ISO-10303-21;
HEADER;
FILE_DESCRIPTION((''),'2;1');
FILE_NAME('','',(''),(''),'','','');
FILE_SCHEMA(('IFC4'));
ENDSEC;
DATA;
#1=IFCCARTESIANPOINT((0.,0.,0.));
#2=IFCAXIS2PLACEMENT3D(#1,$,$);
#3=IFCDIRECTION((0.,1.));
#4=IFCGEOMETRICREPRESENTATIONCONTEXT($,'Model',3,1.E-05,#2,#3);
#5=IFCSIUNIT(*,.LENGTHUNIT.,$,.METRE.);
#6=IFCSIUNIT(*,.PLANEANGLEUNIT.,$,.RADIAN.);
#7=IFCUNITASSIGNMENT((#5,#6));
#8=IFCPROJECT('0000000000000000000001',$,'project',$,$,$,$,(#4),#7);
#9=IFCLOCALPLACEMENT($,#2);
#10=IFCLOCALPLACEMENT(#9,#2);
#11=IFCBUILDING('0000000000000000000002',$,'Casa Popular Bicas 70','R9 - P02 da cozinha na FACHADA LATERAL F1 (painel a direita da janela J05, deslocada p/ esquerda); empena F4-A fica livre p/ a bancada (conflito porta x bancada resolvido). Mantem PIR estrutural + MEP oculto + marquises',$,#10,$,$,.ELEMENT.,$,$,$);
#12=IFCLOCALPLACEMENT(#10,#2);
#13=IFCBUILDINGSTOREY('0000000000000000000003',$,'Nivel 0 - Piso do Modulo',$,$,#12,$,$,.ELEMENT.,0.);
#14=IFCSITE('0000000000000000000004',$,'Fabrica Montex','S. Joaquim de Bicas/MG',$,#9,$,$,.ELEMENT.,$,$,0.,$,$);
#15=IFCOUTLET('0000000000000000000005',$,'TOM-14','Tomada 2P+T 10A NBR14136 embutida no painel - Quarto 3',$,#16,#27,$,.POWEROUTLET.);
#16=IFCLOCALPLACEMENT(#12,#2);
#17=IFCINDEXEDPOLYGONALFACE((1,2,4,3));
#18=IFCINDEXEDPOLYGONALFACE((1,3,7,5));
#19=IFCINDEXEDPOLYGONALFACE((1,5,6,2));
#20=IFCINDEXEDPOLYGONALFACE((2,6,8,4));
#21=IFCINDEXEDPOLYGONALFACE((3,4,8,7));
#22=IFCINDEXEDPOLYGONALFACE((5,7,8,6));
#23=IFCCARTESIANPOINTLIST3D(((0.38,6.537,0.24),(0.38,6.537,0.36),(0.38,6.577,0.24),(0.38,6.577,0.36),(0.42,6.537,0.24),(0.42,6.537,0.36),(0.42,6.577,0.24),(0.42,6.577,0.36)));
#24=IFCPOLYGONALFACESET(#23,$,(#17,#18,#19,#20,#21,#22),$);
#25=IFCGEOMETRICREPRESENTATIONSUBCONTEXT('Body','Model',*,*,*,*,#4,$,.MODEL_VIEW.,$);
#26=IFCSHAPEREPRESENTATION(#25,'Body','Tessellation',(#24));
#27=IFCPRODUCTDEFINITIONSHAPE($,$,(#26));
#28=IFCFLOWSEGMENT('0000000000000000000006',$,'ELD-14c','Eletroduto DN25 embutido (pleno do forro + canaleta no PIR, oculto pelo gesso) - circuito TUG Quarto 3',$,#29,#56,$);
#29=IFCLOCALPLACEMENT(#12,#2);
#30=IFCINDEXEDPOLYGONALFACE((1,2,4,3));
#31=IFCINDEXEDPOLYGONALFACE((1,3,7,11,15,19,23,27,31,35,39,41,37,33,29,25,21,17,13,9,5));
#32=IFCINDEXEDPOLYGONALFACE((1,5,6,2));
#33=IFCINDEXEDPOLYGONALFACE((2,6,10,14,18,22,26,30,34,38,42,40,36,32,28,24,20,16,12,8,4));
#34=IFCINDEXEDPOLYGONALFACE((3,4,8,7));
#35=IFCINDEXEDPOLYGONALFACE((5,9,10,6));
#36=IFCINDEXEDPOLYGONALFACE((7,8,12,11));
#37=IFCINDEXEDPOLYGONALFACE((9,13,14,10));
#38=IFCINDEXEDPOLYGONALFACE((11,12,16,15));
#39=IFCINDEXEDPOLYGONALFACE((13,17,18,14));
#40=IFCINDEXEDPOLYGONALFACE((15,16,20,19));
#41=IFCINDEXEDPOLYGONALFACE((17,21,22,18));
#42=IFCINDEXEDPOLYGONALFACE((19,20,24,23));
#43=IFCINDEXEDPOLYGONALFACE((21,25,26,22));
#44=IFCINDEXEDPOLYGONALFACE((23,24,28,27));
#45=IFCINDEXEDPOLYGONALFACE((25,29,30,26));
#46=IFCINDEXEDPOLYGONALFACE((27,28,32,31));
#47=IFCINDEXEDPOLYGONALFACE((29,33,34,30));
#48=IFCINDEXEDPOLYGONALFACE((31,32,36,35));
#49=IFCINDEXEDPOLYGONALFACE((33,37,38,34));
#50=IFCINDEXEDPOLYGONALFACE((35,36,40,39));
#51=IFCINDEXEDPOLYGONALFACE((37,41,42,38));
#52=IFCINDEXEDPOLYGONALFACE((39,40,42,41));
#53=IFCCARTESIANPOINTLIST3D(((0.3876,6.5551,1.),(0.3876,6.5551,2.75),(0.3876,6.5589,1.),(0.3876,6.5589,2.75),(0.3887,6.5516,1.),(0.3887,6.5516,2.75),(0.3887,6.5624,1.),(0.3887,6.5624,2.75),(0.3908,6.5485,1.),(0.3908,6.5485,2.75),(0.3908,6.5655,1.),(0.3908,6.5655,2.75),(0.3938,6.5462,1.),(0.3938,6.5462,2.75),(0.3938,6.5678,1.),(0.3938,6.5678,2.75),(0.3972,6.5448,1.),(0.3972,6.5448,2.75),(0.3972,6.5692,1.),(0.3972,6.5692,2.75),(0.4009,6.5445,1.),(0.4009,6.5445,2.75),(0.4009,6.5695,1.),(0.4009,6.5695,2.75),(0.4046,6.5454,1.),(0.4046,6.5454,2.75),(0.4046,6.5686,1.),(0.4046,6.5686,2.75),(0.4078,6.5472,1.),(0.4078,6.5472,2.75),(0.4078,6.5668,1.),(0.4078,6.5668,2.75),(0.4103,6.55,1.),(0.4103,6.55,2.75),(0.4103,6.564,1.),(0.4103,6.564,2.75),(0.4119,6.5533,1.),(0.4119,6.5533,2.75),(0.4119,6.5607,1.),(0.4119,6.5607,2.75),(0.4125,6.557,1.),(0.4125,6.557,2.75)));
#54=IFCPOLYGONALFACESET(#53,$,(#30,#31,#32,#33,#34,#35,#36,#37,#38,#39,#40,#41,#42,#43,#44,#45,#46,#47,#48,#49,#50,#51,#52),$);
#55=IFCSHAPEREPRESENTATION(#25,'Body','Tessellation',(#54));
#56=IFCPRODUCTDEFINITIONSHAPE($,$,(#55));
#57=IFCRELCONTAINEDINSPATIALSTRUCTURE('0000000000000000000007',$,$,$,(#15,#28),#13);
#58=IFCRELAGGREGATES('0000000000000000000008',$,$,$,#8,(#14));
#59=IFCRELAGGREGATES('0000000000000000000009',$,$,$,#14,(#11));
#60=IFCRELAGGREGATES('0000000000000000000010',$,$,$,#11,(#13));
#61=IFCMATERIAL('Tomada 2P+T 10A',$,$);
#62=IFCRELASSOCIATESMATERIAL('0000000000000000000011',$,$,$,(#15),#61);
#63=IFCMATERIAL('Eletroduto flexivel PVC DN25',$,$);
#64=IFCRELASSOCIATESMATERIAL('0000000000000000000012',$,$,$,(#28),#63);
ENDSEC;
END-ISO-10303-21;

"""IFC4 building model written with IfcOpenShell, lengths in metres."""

from ifc_helpers import new_model, si_unit, direction, frame, frame_2d, origin, origin_2d, place, context, subcontext, project, spatial, rectangle, circle, extrude, material, element, save


model = new_model("IFC4")

# Units and contexts
model_context = context("Model", 3, precision=1e-05, world=origin(), true_north=direction((0.0, 1.0)))
body_context = subcontext(model_context, "Body", "Model", "MODEL_VIEW")
ifc_project = project(units=[si_unit("LENGTHUNIT", "METRE"), si_unit("PLANEANGLEUNIT", "RADIAN")], contexts=[model_context])

# Site, building, storey
site_placement = place(None, origin())
site = spatial("IfcSite", under=ifc_project, at=site_placement, Name="Fabrica Montex", Description="S. Joaquim de Bicas/MG", CompositionType="ELEMENT", RefElevation=0.0)
building_placement = place(site_placement, origin())
building = spatial("IfcBuilding", under=site, at=building_placement, Name="Casa Popular Bicas 70", Description="R9 - P02 da cozinha na FACHADA LATERAL F1 (painel a direita da janela J05, deslocada p/ esquerda); empena F4-A fica livre p/ a bancada (conflito porta x bancada resolvido). Mantem PIR estrutural + MEP oculto + marquises", CompositionType="ELEMENT")
storey_placement = place(building_placement, origin())
storey = spatial("IfcBuildingStorey", under=building, at=storey_placement, Name="Nivel 0 - Piso do Modulo", CompositionType="ELEMENT", Elevation=0.0)

# Outlet
ifc_material_1 = material(Name="Tomada 2P+T 10A")
outlet_placement = place(storey_placement, frame((0.38, 6.537, 0.24)))
element("IfcOutlet", 1, at=outlet_placement, inside=storey, material=ifc_material_1, Name="TOM-14", Description="Tomada 2P+T 10A NBR14136 embutida no painel - Quarto 3", PredefinedType="POWEROUTLET", context=body_context, shape_type="SweptSolid", body=[
    extrude(rectangle(XDim=0.04, YDim=0.04, at=frame_2d((0.02, 0.02))), origin(), (0.0, 0.0, 1.0), 0.12),
])

# Flow segment
ifc_material_2 = material(Name="Eletroduto flexivel PVC DN25")
flow_segment_placement = place(storey_placement, frame((0.4, 6.557, 2.75), z_axis=(0.0, 0.0, -1.0), x_axis=(1.0, 0.0, 0.0)))
element("IfcFlowSegment", 2, at=flow_segment_placement, inside=storey, material=ifc_material_2, Name="ELD-14c", Description="Eletroduto DN25 embutido (pleno do forro + canaleta no PIR, oculto pelo gesso) - circuito TUG Quarto 3", context=body_context, shape_type="SweptSolid", body=[
    extrude(circle(Radius=0.0125, at=origin_2d()), origin(), (0.0, 0.0, 1.0), 1.75),
])

save(model, "model.ifc")
